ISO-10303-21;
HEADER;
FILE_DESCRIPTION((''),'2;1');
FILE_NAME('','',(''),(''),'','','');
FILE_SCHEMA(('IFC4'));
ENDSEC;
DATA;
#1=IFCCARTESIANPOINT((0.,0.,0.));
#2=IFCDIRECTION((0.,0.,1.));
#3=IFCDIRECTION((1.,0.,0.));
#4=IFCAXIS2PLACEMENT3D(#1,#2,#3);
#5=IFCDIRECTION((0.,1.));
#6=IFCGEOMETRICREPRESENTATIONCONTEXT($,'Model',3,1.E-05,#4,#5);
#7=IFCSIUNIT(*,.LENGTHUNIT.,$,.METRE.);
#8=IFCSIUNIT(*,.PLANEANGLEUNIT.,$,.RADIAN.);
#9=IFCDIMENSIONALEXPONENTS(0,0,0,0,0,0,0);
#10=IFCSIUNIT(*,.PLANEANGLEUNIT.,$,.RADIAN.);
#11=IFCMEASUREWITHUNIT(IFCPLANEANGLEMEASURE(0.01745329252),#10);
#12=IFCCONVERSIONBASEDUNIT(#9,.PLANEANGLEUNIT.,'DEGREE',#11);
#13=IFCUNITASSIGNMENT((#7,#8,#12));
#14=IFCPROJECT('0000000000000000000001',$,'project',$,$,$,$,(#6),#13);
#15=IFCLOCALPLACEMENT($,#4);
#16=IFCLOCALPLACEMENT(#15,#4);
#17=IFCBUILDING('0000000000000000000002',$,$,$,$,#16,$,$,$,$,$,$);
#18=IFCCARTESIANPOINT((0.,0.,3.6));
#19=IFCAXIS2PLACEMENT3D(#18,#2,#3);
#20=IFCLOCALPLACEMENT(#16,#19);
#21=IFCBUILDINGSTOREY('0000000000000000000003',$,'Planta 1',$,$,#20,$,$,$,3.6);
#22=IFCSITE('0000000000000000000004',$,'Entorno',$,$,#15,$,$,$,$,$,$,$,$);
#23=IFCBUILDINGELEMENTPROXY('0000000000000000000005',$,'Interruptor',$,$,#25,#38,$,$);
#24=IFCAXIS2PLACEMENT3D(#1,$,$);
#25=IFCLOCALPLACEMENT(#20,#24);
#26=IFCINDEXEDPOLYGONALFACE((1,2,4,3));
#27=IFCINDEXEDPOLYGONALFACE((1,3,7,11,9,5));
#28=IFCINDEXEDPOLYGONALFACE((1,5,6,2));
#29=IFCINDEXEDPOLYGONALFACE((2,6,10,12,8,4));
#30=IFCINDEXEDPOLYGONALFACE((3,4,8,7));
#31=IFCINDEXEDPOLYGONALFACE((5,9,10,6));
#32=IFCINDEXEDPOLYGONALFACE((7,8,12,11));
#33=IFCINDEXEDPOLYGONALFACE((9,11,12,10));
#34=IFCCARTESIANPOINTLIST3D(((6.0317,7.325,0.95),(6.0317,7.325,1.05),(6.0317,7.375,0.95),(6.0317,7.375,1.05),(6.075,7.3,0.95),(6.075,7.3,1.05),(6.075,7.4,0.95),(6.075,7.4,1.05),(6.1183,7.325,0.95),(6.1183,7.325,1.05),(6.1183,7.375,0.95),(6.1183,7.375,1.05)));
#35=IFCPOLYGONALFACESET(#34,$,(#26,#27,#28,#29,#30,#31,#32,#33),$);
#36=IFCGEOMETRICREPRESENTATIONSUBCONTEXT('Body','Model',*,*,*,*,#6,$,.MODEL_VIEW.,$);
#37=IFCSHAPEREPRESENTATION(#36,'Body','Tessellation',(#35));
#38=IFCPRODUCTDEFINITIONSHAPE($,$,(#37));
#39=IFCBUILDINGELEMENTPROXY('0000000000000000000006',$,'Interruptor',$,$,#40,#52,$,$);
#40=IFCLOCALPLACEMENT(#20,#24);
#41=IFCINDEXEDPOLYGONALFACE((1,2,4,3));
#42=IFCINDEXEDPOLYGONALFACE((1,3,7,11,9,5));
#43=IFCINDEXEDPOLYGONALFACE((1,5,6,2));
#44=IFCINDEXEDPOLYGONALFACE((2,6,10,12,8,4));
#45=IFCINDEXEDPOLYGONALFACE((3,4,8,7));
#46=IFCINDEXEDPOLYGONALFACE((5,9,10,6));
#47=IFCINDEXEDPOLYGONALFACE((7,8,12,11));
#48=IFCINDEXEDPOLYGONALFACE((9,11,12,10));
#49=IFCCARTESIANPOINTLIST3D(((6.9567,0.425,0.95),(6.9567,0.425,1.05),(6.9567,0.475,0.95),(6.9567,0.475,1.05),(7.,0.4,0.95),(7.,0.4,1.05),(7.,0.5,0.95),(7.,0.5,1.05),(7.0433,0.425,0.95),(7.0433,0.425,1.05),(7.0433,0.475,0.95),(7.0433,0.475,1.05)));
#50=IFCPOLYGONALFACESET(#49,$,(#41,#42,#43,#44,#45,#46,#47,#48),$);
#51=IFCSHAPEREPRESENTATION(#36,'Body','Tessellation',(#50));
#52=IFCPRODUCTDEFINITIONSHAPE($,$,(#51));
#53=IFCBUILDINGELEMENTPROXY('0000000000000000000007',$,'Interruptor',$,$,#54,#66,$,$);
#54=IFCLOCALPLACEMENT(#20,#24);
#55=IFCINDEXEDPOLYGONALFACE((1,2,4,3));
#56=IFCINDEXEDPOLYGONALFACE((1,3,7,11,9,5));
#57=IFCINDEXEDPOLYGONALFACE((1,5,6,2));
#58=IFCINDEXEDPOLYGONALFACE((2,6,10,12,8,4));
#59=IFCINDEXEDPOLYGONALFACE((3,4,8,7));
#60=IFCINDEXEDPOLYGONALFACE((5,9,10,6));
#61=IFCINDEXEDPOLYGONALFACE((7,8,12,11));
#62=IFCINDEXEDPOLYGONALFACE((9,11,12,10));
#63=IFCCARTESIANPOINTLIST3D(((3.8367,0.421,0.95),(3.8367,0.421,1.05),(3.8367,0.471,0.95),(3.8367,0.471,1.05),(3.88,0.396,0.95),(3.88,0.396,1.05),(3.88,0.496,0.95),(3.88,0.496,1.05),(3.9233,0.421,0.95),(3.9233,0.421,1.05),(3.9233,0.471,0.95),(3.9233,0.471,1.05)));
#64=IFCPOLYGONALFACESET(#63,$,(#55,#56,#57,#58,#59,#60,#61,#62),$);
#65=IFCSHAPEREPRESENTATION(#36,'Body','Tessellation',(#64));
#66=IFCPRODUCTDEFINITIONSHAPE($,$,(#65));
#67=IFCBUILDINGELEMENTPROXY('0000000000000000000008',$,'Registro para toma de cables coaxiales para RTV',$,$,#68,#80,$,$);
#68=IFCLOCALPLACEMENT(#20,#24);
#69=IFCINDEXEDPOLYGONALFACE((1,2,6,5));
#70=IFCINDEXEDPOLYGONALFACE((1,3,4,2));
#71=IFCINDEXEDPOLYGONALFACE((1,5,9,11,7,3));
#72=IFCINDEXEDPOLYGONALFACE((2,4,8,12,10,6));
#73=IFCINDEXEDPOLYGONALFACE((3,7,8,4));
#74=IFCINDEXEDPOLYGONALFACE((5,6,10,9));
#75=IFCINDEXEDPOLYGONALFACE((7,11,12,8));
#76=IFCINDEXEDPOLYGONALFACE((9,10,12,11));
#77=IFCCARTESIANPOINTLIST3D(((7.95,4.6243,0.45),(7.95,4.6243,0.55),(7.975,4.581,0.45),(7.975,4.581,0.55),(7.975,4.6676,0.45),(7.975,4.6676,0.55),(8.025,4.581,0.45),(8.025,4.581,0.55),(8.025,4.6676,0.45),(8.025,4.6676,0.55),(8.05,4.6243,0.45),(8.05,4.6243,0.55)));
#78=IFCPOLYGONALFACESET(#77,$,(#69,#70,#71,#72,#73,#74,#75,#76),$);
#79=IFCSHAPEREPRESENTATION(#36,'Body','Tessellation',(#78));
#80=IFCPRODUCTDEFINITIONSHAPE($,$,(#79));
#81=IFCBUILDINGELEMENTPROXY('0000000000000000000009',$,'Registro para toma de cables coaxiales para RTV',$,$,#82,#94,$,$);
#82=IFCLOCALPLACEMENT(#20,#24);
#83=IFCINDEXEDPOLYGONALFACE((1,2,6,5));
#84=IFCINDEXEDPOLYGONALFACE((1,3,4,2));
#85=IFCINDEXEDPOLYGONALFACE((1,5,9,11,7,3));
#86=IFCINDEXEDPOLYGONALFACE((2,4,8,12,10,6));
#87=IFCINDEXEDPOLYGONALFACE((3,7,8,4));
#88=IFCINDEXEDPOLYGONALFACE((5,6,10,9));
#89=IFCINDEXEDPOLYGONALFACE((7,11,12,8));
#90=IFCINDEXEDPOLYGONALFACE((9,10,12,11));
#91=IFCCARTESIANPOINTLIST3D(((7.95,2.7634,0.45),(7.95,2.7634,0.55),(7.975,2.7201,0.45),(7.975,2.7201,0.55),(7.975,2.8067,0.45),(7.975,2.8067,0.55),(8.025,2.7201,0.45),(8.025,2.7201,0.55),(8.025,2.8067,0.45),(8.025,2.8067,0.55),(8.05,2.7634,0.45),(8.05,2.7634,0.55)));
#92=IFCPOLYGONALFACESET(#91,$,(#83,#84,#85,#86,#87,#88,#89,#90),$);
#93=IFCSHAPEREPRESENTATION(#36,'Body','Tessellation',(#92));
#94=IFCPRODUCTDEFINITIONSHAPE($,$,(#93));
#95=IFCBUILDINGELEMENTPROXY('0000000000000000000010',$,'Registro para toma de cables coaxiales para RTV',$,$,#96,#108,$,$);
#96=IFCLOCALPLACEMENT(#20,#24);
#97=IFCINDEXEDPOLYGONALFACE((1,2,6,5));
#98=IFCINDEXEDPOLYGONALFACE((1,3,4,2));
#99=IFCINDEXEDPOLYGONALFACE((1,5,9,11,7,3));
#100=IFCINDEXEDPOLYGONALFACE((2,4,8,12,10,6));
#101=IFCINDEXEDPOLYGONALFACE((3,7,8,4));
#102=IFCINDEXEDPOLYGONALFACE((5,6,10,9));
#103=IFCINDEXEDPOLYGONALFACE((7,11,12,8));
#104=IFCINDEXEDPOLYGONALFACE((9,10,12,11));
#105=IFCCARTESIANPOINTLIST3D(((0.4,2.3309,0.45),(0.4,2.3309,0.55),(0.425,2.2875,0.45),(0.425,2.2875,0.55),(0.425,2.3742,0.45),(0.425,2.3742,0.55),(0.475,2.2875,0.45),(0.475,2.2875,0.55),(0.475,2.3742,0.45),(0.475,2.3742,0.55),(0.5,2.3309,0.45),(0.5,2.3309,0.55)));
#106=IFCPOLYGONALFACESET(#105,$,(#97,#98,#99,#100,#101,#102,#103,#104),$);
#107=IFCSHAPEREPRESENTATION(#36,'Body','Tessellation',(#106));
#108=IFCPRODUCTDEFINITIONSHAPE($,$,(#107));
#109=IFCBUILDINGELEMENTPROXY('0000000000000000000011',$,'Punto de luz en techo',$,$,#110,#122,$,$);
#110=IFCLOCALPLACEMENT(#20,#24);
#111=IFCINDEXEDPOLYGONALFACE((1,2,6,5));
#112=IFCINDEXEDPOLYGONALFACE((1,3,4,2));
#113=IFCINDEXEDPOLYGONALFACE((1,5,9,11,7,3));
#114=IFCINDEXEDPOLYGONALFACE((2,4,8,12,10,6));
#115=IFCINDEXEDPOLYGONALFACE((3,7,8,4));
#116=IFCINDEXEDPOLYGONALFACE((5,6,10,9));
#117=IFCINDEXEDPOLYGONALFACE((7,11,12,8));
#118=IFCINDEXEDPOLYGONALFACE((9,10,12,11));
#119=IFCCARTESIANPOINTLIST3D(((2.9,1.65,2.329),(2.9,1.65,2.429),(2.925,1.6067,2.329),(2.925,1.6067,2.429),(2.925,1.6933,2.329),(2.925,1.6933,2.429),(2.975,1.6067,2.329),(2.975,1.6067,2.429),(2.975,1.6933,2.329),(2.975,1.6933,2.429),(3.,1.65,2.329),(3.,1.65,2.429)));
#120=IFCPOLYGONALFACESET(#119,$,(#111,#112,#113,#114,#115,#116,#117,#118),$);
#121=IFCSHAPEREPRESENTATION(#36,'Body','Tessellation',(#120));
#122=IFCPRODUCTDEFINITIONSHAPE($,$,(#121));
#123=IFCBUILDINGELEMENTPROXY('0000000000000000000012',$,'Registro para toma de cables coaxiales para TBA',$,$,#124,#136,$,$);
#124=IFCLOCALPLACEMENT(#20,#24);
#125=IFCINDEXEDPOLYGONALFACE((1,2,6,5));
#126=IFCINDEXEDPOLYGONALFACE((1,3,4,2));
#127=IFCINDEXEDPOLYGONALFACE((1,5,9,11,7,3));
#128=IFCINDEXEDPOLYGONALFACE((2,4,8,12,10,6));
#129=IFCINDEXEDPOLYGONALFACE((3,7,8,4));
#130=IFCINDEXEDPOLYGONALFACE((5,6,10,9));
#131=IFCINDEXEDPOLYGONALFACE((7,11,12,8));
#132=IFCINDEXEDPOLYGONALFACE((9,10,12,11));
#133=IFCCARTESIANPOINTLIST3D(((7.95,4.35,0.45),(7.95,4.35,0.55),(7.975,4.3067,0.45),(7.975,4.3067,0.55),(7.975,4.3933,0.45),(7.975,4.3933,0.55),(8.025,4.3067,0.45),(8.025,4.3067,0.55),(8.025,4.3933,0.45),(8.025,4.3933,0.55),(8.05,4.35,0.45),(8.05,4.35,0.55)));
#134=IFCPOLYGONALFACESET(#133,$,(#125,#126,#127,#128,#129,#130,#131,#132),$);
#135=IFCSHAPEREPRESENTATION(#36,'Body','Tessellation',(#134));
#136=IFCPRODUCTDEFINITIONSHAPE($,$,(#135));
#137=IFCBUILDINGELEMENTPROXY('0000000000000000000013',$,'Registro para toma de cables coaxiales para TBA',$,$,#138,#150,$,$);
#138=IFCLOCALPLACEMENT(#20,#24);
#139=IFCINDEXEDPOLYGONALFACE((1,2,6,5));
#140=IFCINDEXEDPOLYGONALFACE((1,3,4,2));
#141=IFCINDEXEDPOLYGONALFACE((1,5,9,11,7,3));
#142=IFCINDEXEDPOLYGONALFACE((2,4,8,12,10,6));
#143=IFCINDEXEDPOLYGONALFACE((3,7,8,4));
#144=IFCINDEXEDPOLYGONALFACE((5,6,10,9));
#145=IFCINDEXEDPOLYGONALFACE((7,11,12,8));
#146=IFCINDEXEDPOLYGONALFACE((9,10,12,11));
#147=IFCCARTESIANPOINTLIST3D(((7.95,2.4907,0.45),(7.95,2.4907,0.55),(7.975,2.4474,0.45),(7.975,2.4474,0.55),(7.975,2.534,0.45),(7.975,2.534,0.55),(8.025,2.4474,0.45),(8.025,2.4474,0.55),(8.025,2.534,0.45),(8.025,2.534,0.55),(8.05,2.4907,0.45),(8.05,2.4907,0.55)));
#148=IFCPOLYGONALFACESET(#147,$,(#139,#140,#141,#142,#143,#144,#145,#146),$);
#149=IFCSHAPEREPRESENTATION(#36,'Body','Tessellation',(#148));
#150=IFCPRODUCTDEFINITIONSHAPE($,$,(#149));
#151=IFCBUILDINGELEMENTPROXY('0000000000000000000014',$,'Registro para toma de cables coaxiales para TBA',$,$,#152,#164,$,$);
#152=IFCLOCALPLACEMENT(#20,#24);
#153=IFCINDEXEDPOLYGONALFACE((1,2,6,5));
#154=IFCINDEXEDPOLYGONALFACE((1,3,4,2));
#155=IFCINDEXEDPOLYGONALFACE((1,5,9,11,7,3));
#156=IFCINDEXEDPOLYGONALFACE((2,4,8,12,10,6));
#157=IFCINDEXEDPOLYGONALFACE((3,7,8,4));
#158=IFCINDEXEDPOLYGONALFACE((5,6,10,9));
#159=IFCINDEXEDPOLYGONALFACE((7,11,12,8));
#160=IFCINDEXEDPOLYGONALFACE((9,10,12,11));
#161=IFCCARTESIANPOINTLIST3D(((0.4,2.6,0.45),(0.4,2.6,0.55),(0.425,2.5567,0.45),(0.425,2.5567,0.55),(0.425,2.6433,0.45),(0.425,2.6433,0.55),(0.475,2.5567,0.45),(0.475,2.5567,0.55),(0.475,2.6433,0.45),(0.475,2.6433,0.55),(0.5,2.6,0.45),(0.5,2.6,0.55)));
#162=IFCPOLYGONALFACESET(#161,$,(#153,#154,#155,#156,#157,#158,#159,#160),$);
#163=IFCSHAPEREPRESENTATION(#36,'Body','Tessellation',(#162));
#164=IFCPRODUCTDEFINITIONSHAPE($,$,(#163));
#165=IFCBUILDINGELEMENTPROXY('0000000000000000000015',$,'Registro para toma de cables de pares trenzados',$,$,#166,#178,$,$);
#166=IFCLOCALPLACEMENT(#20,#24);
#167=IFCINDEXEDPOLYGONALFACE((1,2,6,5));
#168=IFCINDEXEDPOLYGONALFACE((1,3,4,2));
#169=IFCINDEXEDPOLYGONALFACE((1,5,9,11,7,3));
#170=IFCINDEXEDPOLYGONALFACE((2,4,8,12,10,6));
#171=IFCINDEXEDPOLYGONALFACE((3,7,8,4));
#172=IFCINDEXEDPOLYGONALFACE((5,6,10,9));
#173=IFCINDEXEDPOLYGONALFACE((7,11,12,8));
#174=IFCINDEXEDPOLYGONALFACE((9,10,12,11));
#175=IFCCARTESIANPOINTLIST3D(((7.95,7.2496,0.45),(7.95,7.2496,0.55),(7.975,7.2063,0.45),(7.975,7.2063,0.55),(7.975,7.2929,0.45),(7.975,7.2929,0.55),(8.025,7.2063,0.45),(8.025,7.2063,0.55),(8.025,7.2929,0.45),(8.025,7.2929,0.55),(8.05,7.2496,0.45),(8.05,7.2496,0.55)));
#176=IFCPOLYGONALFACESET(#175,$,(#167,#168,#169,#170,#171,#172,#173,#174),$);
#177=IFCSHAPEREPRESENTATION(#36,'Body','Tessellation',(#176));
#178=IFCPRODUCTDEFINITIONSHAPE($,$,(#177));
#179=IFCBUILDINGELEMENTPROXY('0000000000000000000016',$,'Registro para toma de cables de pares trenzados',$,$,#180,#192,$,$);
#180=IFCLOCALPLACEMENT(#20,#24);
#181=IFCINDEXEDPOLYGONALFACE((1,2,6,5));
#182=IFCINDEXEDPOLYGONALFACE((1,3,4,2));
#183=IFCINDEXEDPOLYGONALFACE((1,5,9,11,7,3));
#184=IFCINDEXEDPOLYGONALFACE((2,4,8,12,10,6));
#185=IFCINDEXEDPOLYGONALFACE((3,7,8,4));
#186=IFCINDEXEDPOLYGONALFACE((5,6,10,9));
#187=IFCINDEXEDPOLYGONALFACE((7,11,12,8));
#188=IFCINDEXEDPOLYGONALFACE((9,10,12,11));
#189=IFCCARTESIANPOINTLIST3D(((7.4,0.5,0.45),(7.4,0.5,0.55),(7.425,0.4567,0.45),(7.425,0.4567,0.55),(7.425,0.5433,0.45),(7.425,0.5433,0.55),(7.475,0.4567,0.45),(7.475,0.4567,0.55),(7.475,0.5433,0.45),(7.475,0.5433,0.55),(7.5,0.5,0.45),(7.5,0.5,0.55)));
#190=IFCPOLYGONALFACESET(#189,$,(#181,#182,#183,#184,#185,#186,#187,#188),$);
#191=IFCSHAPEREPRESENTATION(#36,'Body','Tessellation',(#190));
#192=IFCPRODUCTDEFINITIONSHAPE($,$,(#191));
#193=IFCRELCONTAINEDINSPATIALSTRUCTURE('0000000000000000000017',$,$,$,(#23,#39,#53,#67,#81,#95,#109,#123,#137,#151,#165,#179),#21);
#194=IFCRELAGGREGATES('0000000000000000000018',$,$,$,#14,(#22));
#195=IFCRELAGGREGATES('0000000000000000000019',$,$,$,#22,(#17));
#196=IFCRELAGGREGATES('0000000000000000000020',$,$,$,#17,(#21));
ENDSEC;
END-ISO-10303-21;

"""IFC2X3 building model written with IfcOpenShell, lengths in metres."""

from ifc_helpers import new_model, entity, si_unit, converted_unit, direction, frame, origin_with_axes, place, context, subcontext, project, spatial, polyline, outline, extrude, source, transform, mapped, element, save


model = new_model("IFC2X3")

# Units and contexts
model_context = context("Model", 3, precision=1e-05, world=origin_with_axes(), true_north=direction((0.0, 1.0)))
body_context = subcontext(model_context, "Body", "Model", "MODEL_VIEW")
ifc_project = project(units=[si_unit("LENGTHUNIT", "METRE"), si_unit("PLANEANGLEUNIT", "RADIAN"), converted_unit("PLANEANGLEUNIT", "DEGREE", entity("IfcPlaneAngleMeasure", 0.01745329252), si_unit("PLANEANGLEUNIT", "RADIAN"), dimensions=[0, 0, 0, 0, 0, 0, 0])], contexts=[model_context])

# Site, building, storey
site_placement = place(None, origin_with_axes())
site = spatial("IfcSite", under=ifc_project, at=site_placement, Name="Entorno")
building_placement = place(site_placement, origin_with_axes())
building = spatial("IfcBuilding", under=site, at=building_placement)
storey_placement = place(building_placement, frame((0.0, 0.0, 3.6), z_axis=(0.0, 0.0, 1.0), x_axis=(1.0, 0.0, 0.0)))
storey = spatial("IfcBuildingStorey", under=building, at=storey_placement, Name="Planta 1", Elevation=3.6)

# Building element proxies
shared_shape_1 = source(origin_with_axes(), body_context, "Body", "SolidModel", [
    extrude(outline(polyline([(0.05, 0.0), (0.025, 0.0433), (-0.025, 0.0433), (-0.05, 0.0), (-0.025, -0.0433), (0.025, -0.0433), (0.05, 0.0)])), frame((0.0, 0.0, -0.05), z_axis=(0.0, 0.0, 1.0), x_axis=(1.0, 0.0, 0.0)), (0.0, 0.0, 1.0), 0.1),
])
proxy_1_placement = place(storey_placement, frame((0.0, 0.0, -3.6), z_axis=(0.0, 0.0, 1.0), x_axis=(1.0, 0.0, 0.0)))
element("IfcBuildingElementProxy", 1, at=proxy_1_placement, inside=storey, Name="Interruptor", context=body_context, shape_type="Brep", body=[
    mapped(shared_shape_1, transform((6.075, 7.35, 4.6), x_axis=(0.0, 1.0, 0.0), y_axis=(-1.0, 0.0, 0.0), z_axis=(0.0, 0.0, 1.0))),
])
proxy_2_placement = place(storey_placement, frame((0.0, 0.0, -3.6), z_axis=(0.0, 0.0, 1.0), x_axis=(1.0, 0.0, 0.0)))
element("IfcBuildingElementProxy", 2, at=proxy_2_placement, inside=storey, Name="Interruptor", context=body_context, shape_type="Brep", body=[
    mapped(shared_shape_1, transform((7.0, 0.45, 4.6), x_axis=(0.0, 1.0, 0.0), y_axis=(-1.0, 0.0, 0.0), z_axis=(0.0, 0.0, 1.0))),
])
proxy_3_placement = place(storey_placement, frame((0.0, 0.0, -3.6), z_axis=(0.0, 0.0, 1.0), x_axis=(1.0, 0.0, 0.0)))
element("IfcBuildingElementProxy", 3, at=proxy_3_placement, inside=storey, Name="Interruptor", context=body_context, shape_type="Brep", body=[
    mapped(shared_shape_1, transform((3.88, 0.446, 4.6), x_axis=(0.0, 1.0, 0.0), y_axis=(-1.0, 0.0, 0.0), z_axis=(0.0, 0.0, 1.0))),
])
shared_shape_2 = source(origin_with_axes(), body_context, "Body", "SolidModel", [
    extrude(outline(polyline([(0.05, 0.0), (0.025, 0.0433), (-0.025, 0.0433), (-0.05, 0.0), (-0.025, -0.0433), (0.025, -0.0433), (0.05, 0.0)])), frame((0.0, 0.0, -0.05), z_axis=(0.0, 0.0, 1.0), x_axis=(1.0, 0.0, 0.0)), (0.0, 0.0, 1.0), 0.1),
])
proxy_4_placement = place(storey_placement, frame((0.0, 0.0, -3.6), z_axis=(0.0, 0.0, 1.0), x_axis=(1.0, 0.0, 0.0)))
element("IfcBuildingElementProxy", 4, at=proxy_4_placement, inside=storey, Name="Registro para toma de cables coaxiales para RTV", context=body_context, shape_type="Brep", body=[
    mapped(shared_shape_2, transform((8.0, 4.6243, 4.1), x_axis=(1.0, 0.0, 0.0), y_axis=(0.0, 1.0, 0.0), z_axis=(0.0, 0.0, 1.0))),
])
proxy_5_placement = place(storey_placement, frame((0.0, 0.0, -3.6), z_axis=(0.0, 0.0, 1.0), x_axis=(1.0, 0.0, 0.0)))
element("IfcBuildingElementProxy", 5, at=proxy_5_placement, inside=storey, Name="Registro para toma de cables coaxiales para RTV", context=body_context, shape_type="Brep", body=[
    mapped(shared_shape_2, transform((8.0, 2.7634, 4.1), x_axis=(1.0, 0.0, 0.0), y_axis=(0.0, 1.0, 0.0), z_axis=(0.0, 0.0, 1.0))),
])
proxy_6_placement = place(storey_placement, frame((0.0, 0.0, -3.6), z_axis=(0.0, 0.0, 1.0), x_axis=(1.0, 0.0, 0.0)))
element("IfcBuildingElementProxy", 6, at=proxy_6_placement, inside=storey, Name="Registro para toma de cables coaxiales para RTV", context=body_context, shape_type="Brep", body=[
    mapped(shared_shape_2, transform((0.45, 2.3309, 4.1), x_axis=(1.0, 0.0, 0.0), y_axis=(0.0, 1.0, 0.0), z_axis=(0.0, 0.0, 1.0))),
])
shared_shape_3 = source(origin_with_axes(), body_context, "Body", "SolidModel", [
    extrude(outline(polyline([(0.05, 0.0), (0.025, 0.0433), (-0.025, 0.0433), (-0.05, 0.0), (-0.025, -0.0433), (0.025, -0.0433), (0.05, 0.0)])), frame((0.0, 0.0, -0.05), z_axis=(0.0, 0.0, 1.0), x_axis=(1.0, 0.0, 0.0)), (0.0, 0.0, 1.0), 0.1),
])
proxy_7_placement = place(storey_placement, frame((0.0, 0.0, -3.6), z_axis=(0.0, 0.0, 1.0), x_axis=(1.0, 0.0, 0.0)))
element("IfcBuildingElementProxy", 7, at=proxy_7_placement, inside=storey, Name="Punto de luz en techo", context=body_context, shape_type="Brep", body=[
    mapped(shared_shape_3, transform((2.95, 1.65, 5.979), x_axis=(1.0, 0.0, 0.0), y_axis=(0.0, 1.0, 0.0), z_axis=(0.0, 0.0, 1.0))),
])
shared_shape_4 = source(origin_with_axes(), body_context, "Body", "SolidModel", [
    extrude(outline(polyline([(0.05, 0.0), (0.025, 0.0433), (-0.025, 0.0433), (-0.05, 0.0), (-0.025, -0.0433), (0.025, -0.0433), (0.05, 0.0)])), frame((0.0, 0.0, -0.05), z_axis=(0.0, 0.0, 1.0), x_axis=(1.0, 0.0, 0.0)), (0.0, 0.0, 1.0), 0.1),
])
proxy_8_placement = place(storey_placement, frame((0.0, 0.0, -3.6), z_axis=(0.0, 0.0, 1.0), x_axis=(1.0, 0.0, 0.0)))
element("IfcBuildingElementProxy", 8, at=proxy_8_placement, inside=storey, Name="Registro para toma de cables coaxiales para TBA", context=body_context, shape_type="Brep", body=[
    mapped(shared_shape_4, transform((8.0, 4.35, 4.1), x_axis=(1.0, 0.0, 0.0), y_axis=(0.0, 1.0, 0.0), z_axis=(0.0, 0.0, 1.0))),
])
proxy_9_placement = place(storey_placement, frame((0.0, 0.0, -3.6), z_axis=(0.0, 0.0, 1.0), x_axis=(1.0, 0.0, 0.0)))
element("IfcBuildingElementProxy", 9, at=proxy_9_placement, inside=storey, Name="Registro para toma de cables coaxiales para TBA", context=body_context, shape_type="Brep", body=[
    mapped(shared_shape_4, transform((8.0, 2.4907, 4.1), x_axis=(1.0, 0.0, 0.0), y_axis=(0.0, 1.0, 0.0), z_axis=(0.0, 0.0, 1.0))),
])
proxy_10_placement = place(storey_placement, frame((0.0, 0.0, -3.6), z_axis=(0.0, 0.0, 1.0), x_axis=(1.0, 0.0, 0.0)))
element("IfcBuildingElementProxy", 10, at=proxy_10_placement, inside=storey, Name="Registro para toma de cables coaxiales para TBA", context=body_context, shape_type="Brep", body=[
    mapped(shared_shape_4, transform((0.45, 2.6, 4.1), x_axis=(1.0, 0.0, 0.0), y_axis=(0.0, 1.0, 0.0), z_axis=(0.0, 0.0, 1.0))),
])
shared_shape_5 = source(origin_with_axes(), body_context, "Body", "SolidModel", [
    extrude(outline(polyline([(0.05, 0.0), (0.025, 0.0433), (-0.025, 0.0433), (-0.05, 0.0), (-0.025, -0.0433), (0.025, -0.0433), (0.05, 0.0)])), frame((0.0, 0.0, -0.05), z_axis=(0.0, 0.0, 1.0), x_axis=(1.0, 0.0, 0.0)), (0.0, 0.0, 1.0), 0.1),
])
proxy_11_placement = place(storey_placement, frame((0.0, 0.0, -3.6), z_axis=(0.0, 0.0, 1.0), x_axis=(1.0, 0.0, 0.0)))
element("IfcBuildingElementProxy", 11, at=proxy_11_placement, inside=storey, Name="Registro para toma de cables de pares trenzados", context=body_context, shape_type="Brep", body=[
    mapped(shared_shape_5, transform((8.0, 7.2496, 4.1), x_axis=(1.0, 0.0, 0.0), y_axis=(0.0, 1.0, 0.0), z_axis=(0.0, 0.0, 1.0))),
])
proxy_12_placement = place(storey_placement, frame((0.0, 0.0, -3.6), z_axis=(0.0, 0.0, 1.0), x_axis=(1.0, 0.0, 0.0)))
element("IfcBuildingElementProxy", 12, at=proxy_12_placement, inside=storey, Name="Registro para toma de cables de pares trenzados", context=body_context, shape_type="Brep", body=[
    mapped(shared_shape_5, transform((7.45, 0.5, 4.1), x_axis=(1.0, 0.0, 0.0), y_axis=(0.0, 1.0, 0.0), z_axis=(0.0, 0.0, 1.0))),
])

save(model, "model.ifc")
